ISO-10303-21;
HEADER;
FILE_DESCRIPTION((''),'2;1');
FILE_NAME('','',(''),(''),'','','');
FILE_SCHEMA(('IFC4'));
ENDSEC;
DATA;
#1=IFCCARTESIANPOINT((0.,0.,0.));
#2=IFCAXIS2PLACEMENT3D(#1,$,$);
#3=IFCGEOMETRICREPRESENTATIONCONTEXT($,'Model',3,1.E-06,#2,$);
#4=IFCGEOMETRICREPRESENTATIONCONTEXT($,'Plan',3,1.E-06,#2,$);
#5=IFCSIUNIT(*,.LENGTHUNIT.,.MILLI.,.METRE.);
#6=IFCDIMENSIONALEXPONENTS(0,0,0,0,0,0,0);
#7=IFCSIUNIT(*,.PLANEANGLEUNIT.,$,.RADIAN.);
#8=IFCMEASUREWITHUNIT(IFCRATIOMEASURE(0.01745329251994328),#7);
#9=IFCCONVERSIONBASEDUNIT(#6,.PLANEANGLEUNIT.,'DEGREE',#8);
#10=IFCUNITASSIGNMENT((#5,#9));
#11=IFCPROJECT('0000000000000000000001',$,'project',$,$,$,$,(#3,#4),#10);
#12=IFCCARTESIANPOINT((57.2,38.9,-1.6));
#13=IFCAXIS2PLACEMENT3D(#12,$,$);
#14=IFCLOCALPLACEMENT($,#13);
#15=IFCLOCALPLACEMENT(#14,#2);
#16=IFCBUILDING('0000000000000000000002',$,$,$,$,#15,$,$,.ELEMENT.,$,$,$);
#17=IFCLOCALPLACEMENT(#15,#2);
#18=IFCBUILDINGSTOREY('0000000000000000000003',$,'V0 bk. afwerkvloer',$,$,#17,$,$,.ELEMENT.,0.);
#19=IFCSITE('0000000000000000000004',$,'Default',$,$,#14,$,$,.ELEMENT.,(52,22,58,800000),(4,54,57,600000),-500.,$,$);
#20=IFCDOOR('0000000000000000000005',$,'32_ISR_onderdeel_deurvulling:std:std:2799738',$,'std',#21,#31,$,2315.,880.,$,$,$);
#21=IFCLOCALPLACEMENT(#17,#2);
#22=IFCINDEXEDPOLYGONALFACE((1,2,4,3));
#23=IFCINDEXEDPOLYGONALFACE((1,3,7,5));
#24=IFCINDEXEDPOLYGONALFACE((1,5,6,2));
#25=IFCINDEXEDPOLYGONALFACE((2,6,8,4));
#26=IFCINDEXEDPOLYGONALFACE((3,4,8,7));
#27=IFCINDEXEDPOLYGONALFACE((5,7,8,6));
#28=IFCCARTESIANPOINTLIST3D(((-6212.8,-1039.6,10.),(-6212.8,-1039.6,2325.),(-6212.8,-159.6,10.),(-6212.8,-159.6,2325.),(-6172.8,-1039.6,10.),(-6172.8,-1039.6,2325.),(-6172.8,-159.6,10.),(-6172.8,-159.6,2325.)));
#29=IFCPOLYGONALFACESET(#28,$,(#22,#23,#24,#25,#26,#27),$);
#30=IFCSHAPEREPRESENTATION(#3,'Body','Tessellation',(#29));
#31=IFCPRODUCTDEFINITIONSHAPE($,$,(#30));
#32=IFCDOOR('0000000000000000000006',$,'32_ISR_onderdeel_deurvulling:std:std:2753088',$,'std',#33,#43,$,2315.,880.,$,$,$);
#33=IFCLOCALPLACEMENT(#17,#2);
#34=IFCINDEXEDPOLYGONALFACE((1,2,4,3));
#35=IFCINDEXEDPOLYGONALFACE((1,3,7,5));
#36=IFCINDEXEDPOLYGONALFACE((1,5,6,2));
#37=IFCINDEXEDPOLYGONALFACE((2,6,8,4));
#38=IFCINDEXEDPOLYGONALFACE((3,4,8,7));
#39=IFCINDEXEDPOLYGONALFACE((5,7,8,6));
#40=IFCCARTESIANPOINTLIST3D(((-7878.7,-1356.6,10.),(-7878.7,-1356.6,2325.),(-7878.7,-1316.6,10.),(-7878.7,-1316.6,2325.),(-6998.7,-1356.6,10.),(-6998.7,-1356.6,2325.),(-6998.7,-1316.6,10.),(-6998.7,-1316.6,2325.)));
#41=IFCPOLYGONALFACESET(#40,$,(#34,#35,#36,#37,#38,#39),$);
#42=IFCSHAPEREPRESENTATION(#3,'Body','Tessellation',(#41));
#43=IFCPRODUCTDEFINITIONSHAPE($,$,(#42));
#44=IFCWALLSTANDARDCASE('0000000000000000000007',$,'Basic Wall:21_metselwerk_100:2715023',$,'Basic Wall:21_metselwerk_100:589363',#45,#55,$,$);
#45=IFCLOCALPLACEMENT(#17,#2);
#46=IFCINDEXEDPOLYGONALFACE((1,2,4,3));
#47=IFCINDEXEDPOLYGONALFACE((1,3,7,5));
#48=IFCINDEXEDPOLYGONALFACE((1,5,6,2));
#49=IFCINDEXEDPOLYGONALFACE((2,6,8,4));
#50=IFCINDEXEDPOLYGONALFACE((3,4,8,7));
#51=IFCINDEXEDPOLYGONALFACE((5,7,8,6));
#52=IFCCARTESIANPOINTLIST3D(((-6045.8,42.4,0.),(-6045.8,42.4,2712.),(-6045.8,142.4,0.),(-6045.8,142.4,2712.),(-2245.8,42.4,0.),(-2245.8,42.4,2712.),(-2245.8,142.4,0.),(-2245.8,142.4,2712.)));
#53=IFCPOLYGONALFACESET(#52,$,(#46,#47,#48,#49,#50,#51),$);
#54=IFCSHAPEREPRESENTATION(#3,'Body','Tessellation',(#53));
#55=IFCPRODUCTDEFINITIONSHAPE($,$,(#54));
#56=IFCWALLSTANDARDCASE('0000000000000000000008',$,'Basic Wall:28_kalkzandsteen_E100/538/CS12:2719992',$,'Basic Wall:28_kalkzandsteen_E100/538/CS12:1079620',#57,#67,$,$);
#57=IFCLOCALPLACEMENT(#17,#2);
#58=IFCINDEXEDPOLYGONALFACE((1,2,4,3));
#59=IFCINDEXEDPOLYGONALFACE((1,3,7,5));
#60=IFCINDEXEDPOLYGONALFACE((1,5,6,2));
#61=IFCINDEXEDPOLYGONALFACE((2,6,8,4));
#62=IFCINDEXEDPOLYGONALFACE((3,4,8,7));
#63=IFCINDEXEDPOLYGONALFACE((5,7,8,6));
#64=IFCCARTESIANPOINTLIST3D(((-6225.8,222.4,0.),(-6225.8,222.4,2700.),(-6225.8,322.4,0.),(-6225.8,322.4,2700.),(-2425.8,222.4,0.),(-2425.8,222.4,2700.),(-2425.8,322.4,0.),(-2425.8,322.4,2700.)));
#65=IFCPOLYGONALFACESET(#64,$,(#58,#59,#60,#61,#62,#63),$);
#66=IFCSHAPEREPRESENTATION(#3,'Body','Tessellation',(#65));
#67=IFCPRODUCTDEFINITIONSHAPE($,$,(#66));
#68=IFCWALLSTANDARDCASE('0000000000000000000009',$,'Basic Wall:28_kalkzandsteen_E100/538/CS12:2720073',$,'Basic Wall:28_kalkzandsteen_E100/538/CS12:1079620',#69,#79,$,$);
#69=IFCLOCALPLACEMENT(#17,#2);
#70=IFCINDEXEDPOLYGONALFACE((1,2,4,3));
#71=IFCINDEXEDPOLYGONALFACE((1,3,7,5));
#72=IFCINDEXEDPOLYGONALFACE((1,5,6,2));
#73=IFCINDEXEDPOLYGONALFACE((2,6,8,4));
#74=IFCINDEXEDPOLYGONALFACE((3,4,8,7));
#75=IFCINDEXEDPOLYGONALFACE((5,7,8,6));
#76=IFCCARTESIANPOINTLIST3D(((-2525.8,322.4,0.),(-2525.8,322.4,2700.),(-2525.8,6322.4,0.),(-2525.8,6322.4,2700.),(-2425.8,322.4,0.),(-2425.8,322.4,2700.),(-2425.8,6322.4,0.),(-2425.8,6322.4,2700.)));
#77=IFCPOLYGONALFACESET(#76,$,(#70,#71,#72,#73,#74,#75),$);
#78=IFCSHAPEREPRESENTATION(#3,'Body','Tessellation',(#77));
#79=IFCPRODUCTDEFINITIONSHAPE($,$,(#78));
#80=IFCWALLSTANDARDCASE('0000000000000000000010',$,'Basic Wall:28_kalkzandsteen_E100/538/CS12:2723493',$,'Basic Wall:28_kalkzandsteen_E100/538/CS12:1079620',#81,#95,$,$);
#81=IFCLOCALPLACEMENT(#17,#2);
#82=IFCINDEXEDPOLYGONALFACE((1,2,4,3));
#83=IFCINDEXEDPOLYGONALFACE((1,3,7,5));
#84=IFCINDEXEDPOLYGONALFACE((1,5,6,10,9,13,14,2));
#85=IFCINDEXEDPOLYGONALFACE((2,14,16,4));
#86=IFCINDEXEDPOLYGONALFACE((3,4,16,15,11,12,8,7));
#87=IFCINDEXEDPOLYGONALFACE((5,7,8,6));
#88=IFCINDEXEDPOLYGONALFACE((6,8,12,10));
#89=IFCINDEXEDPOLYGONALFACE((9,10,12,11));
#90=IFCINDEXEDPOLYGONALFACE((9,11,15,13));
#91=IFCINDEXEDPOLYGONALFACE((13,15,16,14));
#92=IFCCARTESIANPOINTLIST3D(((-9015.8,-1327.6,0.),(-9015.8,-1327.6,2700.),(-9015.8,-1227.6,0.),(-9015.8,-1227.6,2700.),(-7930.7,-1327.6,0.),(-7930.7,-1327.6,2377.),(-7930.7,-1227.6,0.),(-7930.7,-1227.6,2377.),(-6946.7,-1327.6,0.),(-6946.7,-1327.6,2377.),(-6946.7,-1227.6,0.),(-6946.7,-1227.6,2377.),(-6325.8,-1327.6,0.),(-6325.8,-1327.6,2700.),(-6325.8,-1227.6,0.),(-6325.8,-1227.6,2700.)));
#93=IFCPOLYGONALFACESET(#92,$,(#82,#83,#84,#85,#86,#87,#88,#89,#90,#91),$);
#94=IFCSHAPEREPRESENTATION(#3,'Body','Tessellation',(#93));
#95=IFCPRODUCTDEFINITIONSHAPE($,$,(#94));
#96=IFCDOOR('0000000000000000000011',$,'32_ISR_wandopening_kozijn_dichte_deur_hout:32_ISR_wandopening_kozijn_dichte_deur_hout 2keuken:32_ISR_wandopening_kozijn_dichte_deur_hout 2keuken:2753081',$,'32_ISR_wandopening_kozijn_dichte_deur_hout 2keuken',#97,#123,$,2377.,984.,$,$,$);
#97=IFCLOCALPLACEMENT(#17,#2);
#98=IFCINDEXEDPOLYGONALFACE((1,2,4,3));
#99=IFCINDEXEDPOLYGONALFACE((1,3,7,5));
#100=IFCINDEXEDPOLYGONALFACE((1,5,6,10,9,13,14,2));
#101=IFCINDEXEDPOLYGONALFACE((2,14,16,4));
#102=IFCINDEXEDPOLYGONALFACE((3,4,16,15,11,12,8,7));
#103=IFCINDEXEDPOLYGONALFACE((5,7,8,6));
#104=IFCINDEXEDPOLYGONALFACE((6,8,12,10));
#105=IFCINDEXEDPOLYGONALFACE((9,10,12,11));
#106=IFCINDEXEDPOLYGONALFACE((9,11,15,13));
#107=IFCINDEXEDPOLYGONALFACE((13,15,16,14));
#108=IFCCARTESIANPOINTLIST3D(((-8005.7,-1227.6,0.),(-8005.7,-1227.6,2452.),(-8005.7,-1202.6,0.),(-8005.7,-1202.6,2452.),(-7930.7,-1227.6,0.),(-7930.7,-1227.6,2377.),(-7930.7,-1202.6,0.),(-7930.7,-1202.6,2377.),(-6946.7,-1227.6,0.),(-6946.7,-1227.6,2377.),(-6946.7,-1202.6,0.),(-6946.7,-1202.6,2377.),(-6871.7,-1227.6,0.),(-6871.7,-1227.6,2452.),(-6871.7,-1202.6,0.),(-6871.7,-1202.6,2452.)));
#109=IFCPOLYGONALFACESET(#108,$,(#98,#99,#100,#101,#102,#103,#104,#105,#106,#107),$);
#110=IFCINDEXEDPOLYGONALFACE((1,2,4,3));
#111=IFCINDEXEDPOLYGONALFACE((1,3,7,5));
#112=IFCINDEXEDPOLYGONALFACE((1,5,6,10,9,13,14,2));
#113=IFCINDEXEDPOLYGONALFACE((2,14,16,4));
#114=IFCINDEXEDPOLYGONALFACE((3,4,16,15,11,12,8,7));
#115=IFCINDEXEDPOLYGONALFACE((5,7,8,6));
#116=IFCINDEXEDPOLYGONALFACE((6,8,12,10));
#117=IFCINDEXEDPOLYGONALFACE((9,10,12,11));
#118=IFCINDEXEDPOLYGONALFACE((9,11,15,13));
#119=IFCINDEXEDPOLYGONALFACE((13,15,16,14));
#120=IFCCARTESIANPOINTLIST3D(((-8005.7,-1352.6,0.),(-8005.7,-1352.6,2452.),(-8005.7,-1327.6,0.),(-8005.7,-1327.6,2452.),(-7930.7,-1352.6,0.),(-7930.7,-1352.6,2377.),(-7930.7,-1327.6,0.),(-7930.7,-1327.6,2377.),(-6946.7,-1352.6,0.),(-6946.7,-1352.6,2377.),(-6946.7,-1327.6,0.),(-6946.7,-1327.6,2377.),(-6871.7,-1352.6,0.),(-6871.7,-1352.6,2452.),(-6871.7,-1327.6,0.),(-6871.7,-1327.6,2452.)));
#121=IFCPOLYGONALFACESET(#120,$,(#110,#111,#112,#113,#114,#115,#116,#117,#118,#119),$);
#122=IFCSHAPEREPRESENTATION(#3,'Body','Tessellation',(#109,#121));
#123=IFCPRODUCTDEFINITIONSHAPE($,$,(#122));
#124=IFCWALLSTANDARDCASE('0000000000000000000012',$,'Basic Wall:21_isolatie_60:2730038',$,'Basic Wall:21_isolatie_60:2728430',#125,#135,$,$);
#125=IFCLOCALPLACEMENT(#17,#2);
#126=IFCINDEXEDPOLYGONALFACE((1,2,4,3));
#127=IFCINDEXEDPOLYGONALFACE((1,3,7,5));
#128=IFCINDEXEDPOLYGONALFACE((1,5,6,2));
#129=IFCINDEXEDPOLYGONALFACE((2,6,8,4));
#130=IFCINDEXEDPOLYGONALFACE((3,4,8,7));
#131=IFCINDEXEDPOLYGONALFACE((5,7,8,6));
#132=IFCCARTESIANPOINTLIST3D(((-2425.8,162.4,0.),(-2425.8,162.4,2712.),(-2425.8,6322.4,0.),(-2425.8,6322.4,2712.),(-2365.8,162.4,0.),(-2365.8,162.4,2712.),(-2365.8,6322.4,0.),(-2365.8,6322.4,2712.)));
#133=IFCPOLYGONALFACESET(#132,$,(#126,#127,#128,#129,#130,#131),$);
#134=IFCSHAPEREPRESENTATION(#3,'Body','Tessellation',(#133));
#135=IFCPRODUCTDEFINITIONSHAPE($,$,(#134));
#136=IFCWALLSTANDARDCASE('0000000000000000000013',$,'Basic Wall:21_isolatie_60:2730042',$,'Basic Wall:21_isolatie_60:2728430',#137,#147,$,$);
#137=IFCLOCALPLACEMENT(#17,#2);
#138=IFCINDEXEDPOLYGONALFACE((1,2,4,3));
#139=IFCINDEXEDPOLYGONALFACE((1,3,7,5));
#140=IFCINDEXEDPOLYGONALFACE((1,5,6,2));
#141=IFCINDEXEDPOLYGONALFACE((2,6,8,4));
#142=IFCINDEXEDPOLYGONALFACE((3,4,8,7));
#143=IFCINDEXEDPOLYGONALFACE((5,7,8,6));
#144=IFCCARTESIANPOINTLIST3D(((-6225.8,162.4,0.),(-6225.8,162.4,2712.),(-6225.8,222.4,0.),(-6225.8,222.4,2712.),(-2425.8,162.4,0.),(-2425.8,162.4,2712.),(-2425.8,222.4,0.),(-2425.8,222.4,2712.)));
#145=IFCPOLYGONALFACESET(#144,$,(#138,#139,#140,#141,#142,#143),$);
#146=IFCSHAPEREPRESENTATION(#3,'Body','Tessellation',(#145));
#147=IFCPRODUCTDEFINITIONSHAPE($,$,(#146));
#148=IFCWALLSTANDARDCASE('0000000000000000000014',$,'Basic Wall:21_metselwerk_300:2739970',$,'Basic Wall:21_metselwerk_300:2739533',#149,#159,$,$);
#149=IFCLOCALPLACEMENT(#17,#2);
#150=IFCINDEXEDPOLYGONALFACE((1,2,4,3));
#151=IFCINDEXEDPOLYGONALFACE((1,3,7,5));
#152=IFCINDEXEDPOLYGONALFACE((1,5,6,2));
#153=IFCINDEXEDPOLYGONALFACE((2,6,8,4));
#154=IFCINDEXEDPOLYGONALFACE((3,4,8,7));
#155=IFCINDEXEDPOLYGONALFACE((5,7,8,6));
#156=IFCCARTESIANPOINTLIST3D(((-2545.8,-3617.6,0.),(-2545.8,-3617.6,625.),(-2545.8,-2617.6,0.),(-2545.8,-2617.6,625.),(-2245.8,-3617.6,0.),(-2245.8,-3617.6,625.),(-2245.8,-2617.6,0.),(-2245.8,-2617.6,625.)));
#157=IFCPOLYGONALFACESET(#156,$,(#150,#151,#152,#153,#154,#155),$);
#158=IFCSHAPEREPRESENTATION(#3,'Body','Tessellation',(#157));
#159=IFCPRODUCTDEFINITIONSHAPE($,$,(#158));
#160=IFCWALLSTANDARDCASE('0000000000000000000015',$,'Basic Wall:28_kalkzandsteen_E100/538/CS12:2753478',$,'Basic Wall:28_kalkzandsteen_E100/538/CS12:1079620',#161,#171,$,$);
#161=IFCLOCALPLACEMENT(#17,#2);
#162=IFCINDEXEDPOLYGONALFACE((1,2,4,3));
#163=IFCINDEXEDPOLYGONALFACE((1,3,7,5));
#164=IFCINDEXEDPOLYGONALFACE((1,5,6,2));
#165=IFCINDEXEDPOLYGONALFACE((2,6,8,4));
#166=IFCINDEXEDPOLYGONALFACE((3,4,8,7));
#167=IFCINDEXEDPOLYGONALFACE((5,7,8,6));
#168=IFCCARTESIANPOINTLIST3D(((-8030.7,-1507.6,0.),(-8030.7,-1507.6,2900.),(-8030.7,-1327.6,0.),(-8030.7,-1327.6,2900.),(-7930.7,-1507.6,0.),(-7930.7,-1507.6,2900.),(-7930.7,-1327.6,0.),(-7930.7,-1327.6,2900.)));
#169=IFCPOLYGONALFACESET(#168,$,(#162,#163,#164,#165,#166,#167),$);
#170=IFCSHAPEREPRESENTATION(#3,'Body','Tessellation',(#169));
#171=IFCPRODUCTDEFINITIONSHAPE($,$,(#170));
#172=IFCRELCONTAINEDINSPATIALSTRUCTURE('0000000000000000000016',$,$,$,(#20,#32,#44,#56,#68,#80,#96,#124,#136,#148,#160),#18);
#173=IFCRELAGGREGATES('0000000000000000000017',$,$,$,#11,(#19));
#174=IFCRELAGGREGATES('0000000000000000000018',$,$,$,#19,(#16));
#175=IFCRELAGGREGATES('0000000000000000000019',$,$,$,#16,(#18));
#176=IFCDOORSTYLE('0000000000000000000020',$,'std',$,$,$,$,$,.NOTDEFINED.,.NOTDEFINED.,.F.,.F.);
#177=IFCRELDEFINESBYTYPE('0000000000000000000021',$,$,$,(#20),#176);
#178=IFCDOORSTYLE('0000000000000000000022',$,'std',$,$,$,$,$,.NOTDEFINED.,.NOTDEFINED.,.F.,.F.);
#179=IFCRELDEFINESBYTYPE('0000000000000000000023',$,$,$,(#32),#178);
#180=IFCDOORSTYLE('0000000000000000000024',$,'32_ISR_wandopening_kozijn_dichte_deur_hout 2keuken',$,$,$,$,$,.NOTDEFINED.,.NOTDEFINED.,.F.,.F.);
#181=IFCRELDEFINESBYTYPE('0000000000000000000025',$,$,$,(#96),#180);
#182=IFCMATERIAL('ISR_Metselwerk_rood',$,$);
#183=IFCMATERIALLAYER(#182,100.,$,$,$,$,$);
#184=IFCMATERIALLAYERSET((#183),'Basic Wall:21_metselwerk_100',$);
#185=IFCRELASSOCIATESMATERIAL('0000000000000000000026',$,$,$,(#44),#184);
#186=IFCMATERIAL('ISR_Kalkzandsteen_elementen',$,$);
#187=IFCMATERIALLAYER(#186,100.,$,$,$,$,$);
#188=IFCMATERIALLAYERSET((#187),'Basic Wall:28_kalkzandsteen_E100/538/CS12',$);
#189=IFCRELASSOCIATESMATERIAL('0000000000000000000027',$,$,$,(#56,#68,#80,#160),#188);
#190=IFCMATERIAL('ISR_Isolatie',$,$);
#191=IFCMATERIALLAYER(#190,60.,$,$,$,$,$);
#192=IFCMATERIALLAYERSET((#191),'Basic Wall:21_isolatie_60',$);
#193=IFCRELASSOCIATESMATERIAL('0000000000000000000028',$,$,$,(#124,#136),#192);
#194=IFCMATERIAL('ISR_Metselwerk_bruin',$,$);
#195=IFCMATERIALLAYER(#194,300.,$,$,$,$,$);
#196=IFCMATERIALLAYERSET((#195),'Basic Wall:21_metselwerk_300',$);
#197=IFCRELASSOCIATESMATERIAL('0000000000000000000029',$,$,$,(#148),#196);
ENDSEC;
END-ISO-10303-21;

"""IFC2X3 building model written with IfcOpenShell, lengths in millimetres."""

from ifc_helpers import new_model, entity, si_unit, converted_unit, frame, frame_2d, origin, origin_2d_with_axis, place, context, project, spatial, polyline, rectangle, outline, extrude, clip, bounded_halfspace, source, transform, mapped, material, layer, layer_set, layer_usage, type_object, type_shapes, element, fill, save


model = new_model("IFC2X3")

# Units and contexts
model_context = context("Model", 3, precision=1e-06, world=origin())
plan_context = context("Plan", 3, precision=1e-06, world=origin())
ifc_project = project(units=[si_unit("LENGTHUNIT", "METRE", prefix="MILLI"), converted_unit("PLANEANGLEUNIT", "DEGREE", entity("IfcRatioMeasure", 0.01745329251994328), si_unit("PLANEANGLEUNIT", "RADIAN"), dimensions=[0, 0, 0, 0, 0, 0, 0])], contexts=[model_context, plan_context])

# Site, building, storey
site_placement = place(None, frame((57.2, 38.9, -1.6)))
site = spatial("IfcSite", under=ifc_project, at=site_placement, Name="Default", CompositionType="ELEMENT", RefLatitude=(52, 22, 58, 800000), RefLongitude=(4, 54, 57, 600000), RefElevation=-500.0)
building_placement = place(site_placement, origin())
building = spatial("IfcBuilding", under=site, at=building_placement, CompositionType="ELEMENT")
storey_placement = place(building_placement, origin())
storey = spatial("IfcBuildingStorey", under=building, at=storey_placement, Name="V0 bk. afwerkvloer", CompositionType="ELEMENT", Elevation=0.0)

# Doors
door_style_1 = type_object("IfcDoorStyle", Name="std", ConstructionType="NOTDEFINED", OperationType="NOTDEFINED", ParameterTakesPrecedence=False, Sizeable=False)
shared_shape_1 = source(origin(), model_context, "Body", "SweptSolid", [
    extrude(rectangle(XDim=880.0, YDim=40.0, at=origin_2d_with_axis()), frame((0.0, 34.0, 0.0)), (0.0, 0.0, 1.0), 2315.0),
])
type_shapes(door_style_1, [shared_shape_1])
door_1_placement = place(storey_placement, frame((-6158.8, -599.6, 10.0), z_axis=(0.0, 0.0, 1.0), x_axis=(0.0, 1.0, 0.0)))
element("IfcDoor", 1, at=door_1_placement, inside=storey, type_object=door_style_1, Name="32_ISR_onderdeel_deurvulling:std:std:2799738", ObjectType="std", OverallHeight=2315.0, OverallWidth=880.0, context=model_context, shape_type="MappedRepresentation", body=[
    mapped(shared_shape_1, transform((0.0, 0.0, 0.0), scale=1.0)),
])
door_style_2 = type_object("IfcDoorStyle", Name="std", ConstructionType="NOTDEFINED", OperationType="NOTDEFINED", ParameterTakesPrecedence=False, Sizeable=False)
shared_shape_2 = source(origin(), model_context, "Body", "SweptSolid", [
    extrude(rectangle(XDim=40.0, YDim=880.0, at=origin_2d_with_axis()), frame((0.0, -34.0, 0.0), z_axis=(0.0, 0.0, 1.0), x_axis=(0.0, -1.0, 0.0)), (0.0, 0.0, 1.0), 2315.0),
])
type_shapes(door_style_2, [shared_shape_2])
door_2_placement = place(storey_placement, frame((-7438.7, -1302.6, 10.0)))
element("IfcDoor", 2, at=door_2_placement, inside=storey, type_object=door_style_2, Name="32_ISR_onderdeel_deurvulling:std:std:2753088", ObjectType="std", OverallHeight=2315.0, OverallWidth=880.0, context=model_context, shape_type="MappedRepresentation", body=[
    mapped(shared_shape_2, transform((0.0, 0.0, 0.0), scale=1.0)),
])

# Walls
ifc_material_1 = material(Name="ISR_Metselwerk_rood")
ifc_layer_1 = layer(ifc_material_1, 100.0)
ifc_layer_set_1 = layer_set([ifc_layer_1], Name="Basic Wall:21_metselwerk_100")
ifc_layer_usage_1 = layer_usage(ifc_layer_set_1, "AXIS2", "NEGATIVE", 50.0)
wall_1_placement = place(storey_placement, frame((-6045.8, 92.4, 0.0)))
element("IfcWallStandardCase", 3, at=wall_1_placement, inside=storey, material=ifc_layer_usage_1, Name="Basic Wall:21_metselwerk_100:2715023", ObjectType="Basic Wall:21_metselwerk_100:589363", context=model_context, shape_type="Clipping", body=[
    clip(extrude(rectangle(XDim=3800.0, YDim=100.0, at=frame_2d((1900.0, 0.0), x_axis=(-1.0, 0.0))), origin(), (0.0, 0.0, 1.0), 2712.0), bounded_halfspace(frame((0.0, -50.0, 2712.0), z_axis=(0.0, 0.0, -1.0), x_axis=(0.0, -1.0, 0.0)), True, frame((0.0, -50.0, 2712.0)), polyline([(0.0, 0.0), (3620.0, 0.0), (3620.0, 100.0), (0.0, 100.0), (0.0, 0.0)]))),
])
ifc_material_2 = material(Name="ISR_Kalkzandsteen_elementen")
ifc_layer_2 = layer(ifc_material_2, 100.0)
ifc_layer_set_2 = layer_set([ifc_layer_2], Name="Basic Wall:28_kalkzandsteen_E100/538/CS12")
ifc_layer_usage_2 = layer_usage(ifc_layer_set_2, "AXIS2", "NEGATIVE", 50.0)
wall_2_placement = place(storey_placement, frame((-6225.8, 272.4, 0.0)))
element("IfcWallStandardCase", 4, at=wall_2_placement, inside=storey, material=ifc_layer_usage_2, Name="Basic Wall:28_kalkzandsteen_E100/538/CS12:2719992", ObjectType="Basic Wall:28_kalkzandsteen_E100/538/CS12:1079620", context=model_context, shape_type="SweptSolid", body=[
    extrude(rectangle(XDim=3800.0, YDim=100.0, at=frame_2d((1900.0, 0.0), x_axis=(-1.0, 0.0))), origin(), (0.0, 0.0, 1.0), 2700.0),
])
ifc_layer_usage_3 = layer_usage(ifc_layer_set_2, "AXIS2", "NEGATIVE", 50.0)
wall_3_placement = place(storey_placement, frame((-2475.8, 322.4, 0.0), z_axis=(0.0, 0.0, 1.0), x_axis=(0.0, 1.0, 0.0)))
element("IfcWallStandardCase", 5, at=wall_3_placement, inside=storey, material=ifc_layer_usage_3, Name="Basic Wall:28_kalkzandsteen_E100/538/CS12:2720073", ObjectType="Basic Wall:28_kalkzandsteen_E100/538/CS12:1079620", context=model_context, shape_type="SweptSolid", body=[
    extrude(rectangle(XDim=6000.0, YDim=100.0, at=frame_2d((3000.0, 0.0), x_axis=(-1.0, 0.0))), origin(), (0.0, 0.0, 1.0), 2700.0),
])

# Wall, opening, door
ifc_layer_usage_4 = layer_usage(ifc_layer_set_2, "AXIS2", "POSITIVE", -50.0)
wall_4_placement = place(storey_placement, frame((-6325.8, -1277.6, 0.0), z_axis=(0.0, 0.0, 1.0), x_axis=(-1.0, 0.0, 0.0)))
wall_4 = element("IfcWallStandardCase", 6, at=wall_4_placement, inside=storey, material=ifc_layer_usage_4, Name="Basic Wall:28_kalkzandsteen_E100/538/CS12:2723493", ObjectType="Basic Wall:28_kalkzandsteen_E100/538/CS12:1079620", context=model_context, shape_type="SweptSolid", body=[
    extrude(rectangle(XDim=2690.0, YDim=100.0, at=frame_2d((1345.0, 0.0), x_axis=(-1.0, 0.0))), origin(), (0.0, 0.0, 1.0), 2700.0),
])
opening_1_placement = place(wall_4_placement, frame((1604.8, 50.0, 0.0)))
opening_1 = element("IfcOpeningElement", 7, at=opening_1_placement, cuts=wall_4, ObjectType="Opening", context=model_context, shape_type="SweptSolid", body=[
    extrude(rectangle(XDim=2377.0, YDim=984.0, at=frame_2d((1188.5, 492.0), x_axis=(1.0, 0.0))), frame((0.0, 0.0, 0.0), z_axis=(0.0, -1.0, 0.0), x_axis=(0.0, 0.0, 1.0)), (0.0, 0.0, 1.0), 100.0),
])
door_style_3 = type_object("IfcDoorStyle", Name="32_ISR_wandopening_kozijn_dichte_deur_hout 2keuken", ConstructionType="NOTDEFINED", OperationType="NOTDEFINED", ParameterTakesPrecedence=False, Sizeable=False)
shared_shape_3 = source(origin(), model_context, "Body", "SweptSolid", [
    extrude(outline(polyline([(-1169.7, 492.0), (1207.2, 492.0), (1207.2, 567.0), (-1244.7, 567.0), (-1244.7, -567.0), (1207.2, -567.0), (1207.2, -492.0), (-1169.7, -492.0), (-1169.7, 492.0)])), frame((492.0, 100.0, 1207.2), z_axis=(0.0, 1.0, 0.0), x_axis=(0.0, 0.0, -1.0)), (0.0, 0.0, 1.0), 25.0),
    extrude(outline(polyline([(-567.0, -1244.7), (567.0, -1244.7), (567.0, 1207.2), (492.0, 1207.2), (492.0, -1169.7), (-492.0, -1169.7), (-492.0, 1207.2), (-567.0, 1207.2), (-567.0, -1244.7)])), frame((492.0, -25.0, 1207.2), z_axis=(0.0, 1.0, 0.0), x_axis=(1.0, 0.0, 0.0)), (0.0, 0.0, 1.0), 25.0),
])
type_shapes(door_style_3, [shared_shape_3])
door_3_placement = place(opening_1_placement, frame((0.0, 0.0, 0.0), z_axis=(0.0, 0.0, 1.0), x_axis=(-1.0, 0.0, 0.0)))
door_3 = element("IfcDoor", 8, at=door_3_placement, inside=storey, type_object=door_style_3, Name="32_ISR_wandopening_kozijn_dichte_deur_hout:32_ISR_wandopening_kozijn_dichte_deur_hout 2keuken:32_ISR_wandopening_kozijn_dichte_deur_hout 2keuken:2753081", ObjectType="32_ISR_wandopening_kozijn_dichte_deur_hout 2keuken", OverallHeight=2377.0, OverallWidth=984.0, context=model_context, shape_type="MappedRepresentation", body=[
    mapped(shared_shape_3, transform((0.0, 0.0, 0.0), scale=1.0)),
])
fill(opening_1, door_3)

# Walls
ifc_material_3 = material(Name="ISR_Isolatie")
ifc_layer_3 = layer(ifc_material_3, 60.0)
ifc_layer_set_3 = layer_set([ifc_layer_3], Name="Basic Wall:21_isolatie_60")
ifc_layer_usage_5 = layer_usage(ifc_layer_set_3, "AXIS2", "NEGATIVE", 30.0)
wall_5_placement = place(storey_placement, frame((-2395.8, 162.4, 0.0), z_axis=(0.0, 0.0, 1.0), x_axis=(0.0, 1.0, 0.0)))
element("IfcWallStandardCase", 9, at=wall_5_placement, inside=storey, material=ifc_layer_usage_5, Name="Basic Wall:21_isolatie_60:2730038", ObjectType="Basic Wall:21_isolatie_60:2728430", context=model_context, shape_type="SweptSolid", body=[
    extrude(rectangle(XDim=6160.0, YDim=60.0, at=frame_2d((3080.0, 0.0), x_axis=(-1.0, 0.0))), origin(), (0.0, 0.0, 1.0), 2712.0),
])
ifc_layer_usage_6 = layer_usage(ifc_layer_set_3, "AXIS2", "NEGATIVE", 30.0)
wall_6_placement = place(storey_placement, frame((-6225.8, 192.4, 0.0)))
element("IfcWallStandardCase", 10, at=wall_6_placement, inside=storey, material=ifc_layer_usage_6, Name="Basic Wall:21_isolatie_60:2730042", ObjectType="Basic Wall:21_isolatie_60:2728430", context=model_context, shape_type="Clipping", body=[
    clip(extrude(rectangle(XDim=3800.0, YDim=60.0, at=frame_2d((1900.0, 0.0), x_axis=(-1.0, 0.0))), origin(), (0.0, 0.0, 1.0), 2712.0), bounded_halfspace(frame((0.0, -30.0, 2712.0), z_axis=(0.0, 0.0, -1.0), x_axis=(0.0, -1.0, 0.0)), True, frame((0.0, -30.0, 2712.0)), polyline([(0.0, 0.0), (60.0, 0.0), (3800.0, 0.0), (3800.0, 60.0), (0.0, 60.0), (0.0, 0.0)]))),
])
ifc_material_4 = material(Name="ISR_Metselwerk_bruin")
ifc_layer_4 = layer(ifc_material_4, 300.0)
ifc_layer_set_4 = layer_set([ifc_layer_4], Name="Basic Wall:21_metselwerk_300")
ifc_layer_usage_7 = layer_usage(ifc_layer_set_4, "AXIS2", "POSITIVE", -150.0)
wall_7_placement = place(storey_placement, frame((-2395.8, -2617.6, 0.0), z_axis=(0.0, 0.0, 1.0), x_axis=(0.0, -1.0, 0.0)))
element("IfcWallStandardCase", 11, at=wall_7_placement, inside=storey, material=ifc_layer_usage_7, Name="Basic Wall:21_metselwerk_300:2739970", ObjectType="Basic Wall:21_metselwerk_300:2739533", context=model_context, shape_type="SweptSolid", body=[
    extrude(rectangle(XDim=1000.0, YDim=300.0, at=frame_2d((500.0, 0.0), x_axis=(-1.0, 0.0))), origin(), (0.0, 0.0, 1.0), 625.0),
])
ifc_layer_usage_8 = layer_usage(ifc_layer_set_2, "AXIS2", "POSITIVE", -50.0)
wall_8_placement = place(storey_placement, frame((-7980.7, -1507.6, 0.0), z_axis=(0.0, 0.0, 1.0), x_axis=(0.0, 1.0, 0.0)))
element("IfcWallStandardCase", 12, at=wall_8_placement, inside=storey, material=ifc_layer_usage_8, Name="Basic Wall:28_kalkzandsteen_E100/538/CS12:2753478", ObjectType="Basic Wall:28_kalkzandsteen_E100/538/CS12:1079620", context=model_context, shape_type="SweptSolid", body=[
    extrude(rectangle(XDim=180.0, YDim=100.0, at=frame_2d((90.0, 0.0), x_axis=(-1.0, 0.0))), origin(), (0.0, 0.0, 1.0), 2900.0),
])

save(model, "model.ifc")
